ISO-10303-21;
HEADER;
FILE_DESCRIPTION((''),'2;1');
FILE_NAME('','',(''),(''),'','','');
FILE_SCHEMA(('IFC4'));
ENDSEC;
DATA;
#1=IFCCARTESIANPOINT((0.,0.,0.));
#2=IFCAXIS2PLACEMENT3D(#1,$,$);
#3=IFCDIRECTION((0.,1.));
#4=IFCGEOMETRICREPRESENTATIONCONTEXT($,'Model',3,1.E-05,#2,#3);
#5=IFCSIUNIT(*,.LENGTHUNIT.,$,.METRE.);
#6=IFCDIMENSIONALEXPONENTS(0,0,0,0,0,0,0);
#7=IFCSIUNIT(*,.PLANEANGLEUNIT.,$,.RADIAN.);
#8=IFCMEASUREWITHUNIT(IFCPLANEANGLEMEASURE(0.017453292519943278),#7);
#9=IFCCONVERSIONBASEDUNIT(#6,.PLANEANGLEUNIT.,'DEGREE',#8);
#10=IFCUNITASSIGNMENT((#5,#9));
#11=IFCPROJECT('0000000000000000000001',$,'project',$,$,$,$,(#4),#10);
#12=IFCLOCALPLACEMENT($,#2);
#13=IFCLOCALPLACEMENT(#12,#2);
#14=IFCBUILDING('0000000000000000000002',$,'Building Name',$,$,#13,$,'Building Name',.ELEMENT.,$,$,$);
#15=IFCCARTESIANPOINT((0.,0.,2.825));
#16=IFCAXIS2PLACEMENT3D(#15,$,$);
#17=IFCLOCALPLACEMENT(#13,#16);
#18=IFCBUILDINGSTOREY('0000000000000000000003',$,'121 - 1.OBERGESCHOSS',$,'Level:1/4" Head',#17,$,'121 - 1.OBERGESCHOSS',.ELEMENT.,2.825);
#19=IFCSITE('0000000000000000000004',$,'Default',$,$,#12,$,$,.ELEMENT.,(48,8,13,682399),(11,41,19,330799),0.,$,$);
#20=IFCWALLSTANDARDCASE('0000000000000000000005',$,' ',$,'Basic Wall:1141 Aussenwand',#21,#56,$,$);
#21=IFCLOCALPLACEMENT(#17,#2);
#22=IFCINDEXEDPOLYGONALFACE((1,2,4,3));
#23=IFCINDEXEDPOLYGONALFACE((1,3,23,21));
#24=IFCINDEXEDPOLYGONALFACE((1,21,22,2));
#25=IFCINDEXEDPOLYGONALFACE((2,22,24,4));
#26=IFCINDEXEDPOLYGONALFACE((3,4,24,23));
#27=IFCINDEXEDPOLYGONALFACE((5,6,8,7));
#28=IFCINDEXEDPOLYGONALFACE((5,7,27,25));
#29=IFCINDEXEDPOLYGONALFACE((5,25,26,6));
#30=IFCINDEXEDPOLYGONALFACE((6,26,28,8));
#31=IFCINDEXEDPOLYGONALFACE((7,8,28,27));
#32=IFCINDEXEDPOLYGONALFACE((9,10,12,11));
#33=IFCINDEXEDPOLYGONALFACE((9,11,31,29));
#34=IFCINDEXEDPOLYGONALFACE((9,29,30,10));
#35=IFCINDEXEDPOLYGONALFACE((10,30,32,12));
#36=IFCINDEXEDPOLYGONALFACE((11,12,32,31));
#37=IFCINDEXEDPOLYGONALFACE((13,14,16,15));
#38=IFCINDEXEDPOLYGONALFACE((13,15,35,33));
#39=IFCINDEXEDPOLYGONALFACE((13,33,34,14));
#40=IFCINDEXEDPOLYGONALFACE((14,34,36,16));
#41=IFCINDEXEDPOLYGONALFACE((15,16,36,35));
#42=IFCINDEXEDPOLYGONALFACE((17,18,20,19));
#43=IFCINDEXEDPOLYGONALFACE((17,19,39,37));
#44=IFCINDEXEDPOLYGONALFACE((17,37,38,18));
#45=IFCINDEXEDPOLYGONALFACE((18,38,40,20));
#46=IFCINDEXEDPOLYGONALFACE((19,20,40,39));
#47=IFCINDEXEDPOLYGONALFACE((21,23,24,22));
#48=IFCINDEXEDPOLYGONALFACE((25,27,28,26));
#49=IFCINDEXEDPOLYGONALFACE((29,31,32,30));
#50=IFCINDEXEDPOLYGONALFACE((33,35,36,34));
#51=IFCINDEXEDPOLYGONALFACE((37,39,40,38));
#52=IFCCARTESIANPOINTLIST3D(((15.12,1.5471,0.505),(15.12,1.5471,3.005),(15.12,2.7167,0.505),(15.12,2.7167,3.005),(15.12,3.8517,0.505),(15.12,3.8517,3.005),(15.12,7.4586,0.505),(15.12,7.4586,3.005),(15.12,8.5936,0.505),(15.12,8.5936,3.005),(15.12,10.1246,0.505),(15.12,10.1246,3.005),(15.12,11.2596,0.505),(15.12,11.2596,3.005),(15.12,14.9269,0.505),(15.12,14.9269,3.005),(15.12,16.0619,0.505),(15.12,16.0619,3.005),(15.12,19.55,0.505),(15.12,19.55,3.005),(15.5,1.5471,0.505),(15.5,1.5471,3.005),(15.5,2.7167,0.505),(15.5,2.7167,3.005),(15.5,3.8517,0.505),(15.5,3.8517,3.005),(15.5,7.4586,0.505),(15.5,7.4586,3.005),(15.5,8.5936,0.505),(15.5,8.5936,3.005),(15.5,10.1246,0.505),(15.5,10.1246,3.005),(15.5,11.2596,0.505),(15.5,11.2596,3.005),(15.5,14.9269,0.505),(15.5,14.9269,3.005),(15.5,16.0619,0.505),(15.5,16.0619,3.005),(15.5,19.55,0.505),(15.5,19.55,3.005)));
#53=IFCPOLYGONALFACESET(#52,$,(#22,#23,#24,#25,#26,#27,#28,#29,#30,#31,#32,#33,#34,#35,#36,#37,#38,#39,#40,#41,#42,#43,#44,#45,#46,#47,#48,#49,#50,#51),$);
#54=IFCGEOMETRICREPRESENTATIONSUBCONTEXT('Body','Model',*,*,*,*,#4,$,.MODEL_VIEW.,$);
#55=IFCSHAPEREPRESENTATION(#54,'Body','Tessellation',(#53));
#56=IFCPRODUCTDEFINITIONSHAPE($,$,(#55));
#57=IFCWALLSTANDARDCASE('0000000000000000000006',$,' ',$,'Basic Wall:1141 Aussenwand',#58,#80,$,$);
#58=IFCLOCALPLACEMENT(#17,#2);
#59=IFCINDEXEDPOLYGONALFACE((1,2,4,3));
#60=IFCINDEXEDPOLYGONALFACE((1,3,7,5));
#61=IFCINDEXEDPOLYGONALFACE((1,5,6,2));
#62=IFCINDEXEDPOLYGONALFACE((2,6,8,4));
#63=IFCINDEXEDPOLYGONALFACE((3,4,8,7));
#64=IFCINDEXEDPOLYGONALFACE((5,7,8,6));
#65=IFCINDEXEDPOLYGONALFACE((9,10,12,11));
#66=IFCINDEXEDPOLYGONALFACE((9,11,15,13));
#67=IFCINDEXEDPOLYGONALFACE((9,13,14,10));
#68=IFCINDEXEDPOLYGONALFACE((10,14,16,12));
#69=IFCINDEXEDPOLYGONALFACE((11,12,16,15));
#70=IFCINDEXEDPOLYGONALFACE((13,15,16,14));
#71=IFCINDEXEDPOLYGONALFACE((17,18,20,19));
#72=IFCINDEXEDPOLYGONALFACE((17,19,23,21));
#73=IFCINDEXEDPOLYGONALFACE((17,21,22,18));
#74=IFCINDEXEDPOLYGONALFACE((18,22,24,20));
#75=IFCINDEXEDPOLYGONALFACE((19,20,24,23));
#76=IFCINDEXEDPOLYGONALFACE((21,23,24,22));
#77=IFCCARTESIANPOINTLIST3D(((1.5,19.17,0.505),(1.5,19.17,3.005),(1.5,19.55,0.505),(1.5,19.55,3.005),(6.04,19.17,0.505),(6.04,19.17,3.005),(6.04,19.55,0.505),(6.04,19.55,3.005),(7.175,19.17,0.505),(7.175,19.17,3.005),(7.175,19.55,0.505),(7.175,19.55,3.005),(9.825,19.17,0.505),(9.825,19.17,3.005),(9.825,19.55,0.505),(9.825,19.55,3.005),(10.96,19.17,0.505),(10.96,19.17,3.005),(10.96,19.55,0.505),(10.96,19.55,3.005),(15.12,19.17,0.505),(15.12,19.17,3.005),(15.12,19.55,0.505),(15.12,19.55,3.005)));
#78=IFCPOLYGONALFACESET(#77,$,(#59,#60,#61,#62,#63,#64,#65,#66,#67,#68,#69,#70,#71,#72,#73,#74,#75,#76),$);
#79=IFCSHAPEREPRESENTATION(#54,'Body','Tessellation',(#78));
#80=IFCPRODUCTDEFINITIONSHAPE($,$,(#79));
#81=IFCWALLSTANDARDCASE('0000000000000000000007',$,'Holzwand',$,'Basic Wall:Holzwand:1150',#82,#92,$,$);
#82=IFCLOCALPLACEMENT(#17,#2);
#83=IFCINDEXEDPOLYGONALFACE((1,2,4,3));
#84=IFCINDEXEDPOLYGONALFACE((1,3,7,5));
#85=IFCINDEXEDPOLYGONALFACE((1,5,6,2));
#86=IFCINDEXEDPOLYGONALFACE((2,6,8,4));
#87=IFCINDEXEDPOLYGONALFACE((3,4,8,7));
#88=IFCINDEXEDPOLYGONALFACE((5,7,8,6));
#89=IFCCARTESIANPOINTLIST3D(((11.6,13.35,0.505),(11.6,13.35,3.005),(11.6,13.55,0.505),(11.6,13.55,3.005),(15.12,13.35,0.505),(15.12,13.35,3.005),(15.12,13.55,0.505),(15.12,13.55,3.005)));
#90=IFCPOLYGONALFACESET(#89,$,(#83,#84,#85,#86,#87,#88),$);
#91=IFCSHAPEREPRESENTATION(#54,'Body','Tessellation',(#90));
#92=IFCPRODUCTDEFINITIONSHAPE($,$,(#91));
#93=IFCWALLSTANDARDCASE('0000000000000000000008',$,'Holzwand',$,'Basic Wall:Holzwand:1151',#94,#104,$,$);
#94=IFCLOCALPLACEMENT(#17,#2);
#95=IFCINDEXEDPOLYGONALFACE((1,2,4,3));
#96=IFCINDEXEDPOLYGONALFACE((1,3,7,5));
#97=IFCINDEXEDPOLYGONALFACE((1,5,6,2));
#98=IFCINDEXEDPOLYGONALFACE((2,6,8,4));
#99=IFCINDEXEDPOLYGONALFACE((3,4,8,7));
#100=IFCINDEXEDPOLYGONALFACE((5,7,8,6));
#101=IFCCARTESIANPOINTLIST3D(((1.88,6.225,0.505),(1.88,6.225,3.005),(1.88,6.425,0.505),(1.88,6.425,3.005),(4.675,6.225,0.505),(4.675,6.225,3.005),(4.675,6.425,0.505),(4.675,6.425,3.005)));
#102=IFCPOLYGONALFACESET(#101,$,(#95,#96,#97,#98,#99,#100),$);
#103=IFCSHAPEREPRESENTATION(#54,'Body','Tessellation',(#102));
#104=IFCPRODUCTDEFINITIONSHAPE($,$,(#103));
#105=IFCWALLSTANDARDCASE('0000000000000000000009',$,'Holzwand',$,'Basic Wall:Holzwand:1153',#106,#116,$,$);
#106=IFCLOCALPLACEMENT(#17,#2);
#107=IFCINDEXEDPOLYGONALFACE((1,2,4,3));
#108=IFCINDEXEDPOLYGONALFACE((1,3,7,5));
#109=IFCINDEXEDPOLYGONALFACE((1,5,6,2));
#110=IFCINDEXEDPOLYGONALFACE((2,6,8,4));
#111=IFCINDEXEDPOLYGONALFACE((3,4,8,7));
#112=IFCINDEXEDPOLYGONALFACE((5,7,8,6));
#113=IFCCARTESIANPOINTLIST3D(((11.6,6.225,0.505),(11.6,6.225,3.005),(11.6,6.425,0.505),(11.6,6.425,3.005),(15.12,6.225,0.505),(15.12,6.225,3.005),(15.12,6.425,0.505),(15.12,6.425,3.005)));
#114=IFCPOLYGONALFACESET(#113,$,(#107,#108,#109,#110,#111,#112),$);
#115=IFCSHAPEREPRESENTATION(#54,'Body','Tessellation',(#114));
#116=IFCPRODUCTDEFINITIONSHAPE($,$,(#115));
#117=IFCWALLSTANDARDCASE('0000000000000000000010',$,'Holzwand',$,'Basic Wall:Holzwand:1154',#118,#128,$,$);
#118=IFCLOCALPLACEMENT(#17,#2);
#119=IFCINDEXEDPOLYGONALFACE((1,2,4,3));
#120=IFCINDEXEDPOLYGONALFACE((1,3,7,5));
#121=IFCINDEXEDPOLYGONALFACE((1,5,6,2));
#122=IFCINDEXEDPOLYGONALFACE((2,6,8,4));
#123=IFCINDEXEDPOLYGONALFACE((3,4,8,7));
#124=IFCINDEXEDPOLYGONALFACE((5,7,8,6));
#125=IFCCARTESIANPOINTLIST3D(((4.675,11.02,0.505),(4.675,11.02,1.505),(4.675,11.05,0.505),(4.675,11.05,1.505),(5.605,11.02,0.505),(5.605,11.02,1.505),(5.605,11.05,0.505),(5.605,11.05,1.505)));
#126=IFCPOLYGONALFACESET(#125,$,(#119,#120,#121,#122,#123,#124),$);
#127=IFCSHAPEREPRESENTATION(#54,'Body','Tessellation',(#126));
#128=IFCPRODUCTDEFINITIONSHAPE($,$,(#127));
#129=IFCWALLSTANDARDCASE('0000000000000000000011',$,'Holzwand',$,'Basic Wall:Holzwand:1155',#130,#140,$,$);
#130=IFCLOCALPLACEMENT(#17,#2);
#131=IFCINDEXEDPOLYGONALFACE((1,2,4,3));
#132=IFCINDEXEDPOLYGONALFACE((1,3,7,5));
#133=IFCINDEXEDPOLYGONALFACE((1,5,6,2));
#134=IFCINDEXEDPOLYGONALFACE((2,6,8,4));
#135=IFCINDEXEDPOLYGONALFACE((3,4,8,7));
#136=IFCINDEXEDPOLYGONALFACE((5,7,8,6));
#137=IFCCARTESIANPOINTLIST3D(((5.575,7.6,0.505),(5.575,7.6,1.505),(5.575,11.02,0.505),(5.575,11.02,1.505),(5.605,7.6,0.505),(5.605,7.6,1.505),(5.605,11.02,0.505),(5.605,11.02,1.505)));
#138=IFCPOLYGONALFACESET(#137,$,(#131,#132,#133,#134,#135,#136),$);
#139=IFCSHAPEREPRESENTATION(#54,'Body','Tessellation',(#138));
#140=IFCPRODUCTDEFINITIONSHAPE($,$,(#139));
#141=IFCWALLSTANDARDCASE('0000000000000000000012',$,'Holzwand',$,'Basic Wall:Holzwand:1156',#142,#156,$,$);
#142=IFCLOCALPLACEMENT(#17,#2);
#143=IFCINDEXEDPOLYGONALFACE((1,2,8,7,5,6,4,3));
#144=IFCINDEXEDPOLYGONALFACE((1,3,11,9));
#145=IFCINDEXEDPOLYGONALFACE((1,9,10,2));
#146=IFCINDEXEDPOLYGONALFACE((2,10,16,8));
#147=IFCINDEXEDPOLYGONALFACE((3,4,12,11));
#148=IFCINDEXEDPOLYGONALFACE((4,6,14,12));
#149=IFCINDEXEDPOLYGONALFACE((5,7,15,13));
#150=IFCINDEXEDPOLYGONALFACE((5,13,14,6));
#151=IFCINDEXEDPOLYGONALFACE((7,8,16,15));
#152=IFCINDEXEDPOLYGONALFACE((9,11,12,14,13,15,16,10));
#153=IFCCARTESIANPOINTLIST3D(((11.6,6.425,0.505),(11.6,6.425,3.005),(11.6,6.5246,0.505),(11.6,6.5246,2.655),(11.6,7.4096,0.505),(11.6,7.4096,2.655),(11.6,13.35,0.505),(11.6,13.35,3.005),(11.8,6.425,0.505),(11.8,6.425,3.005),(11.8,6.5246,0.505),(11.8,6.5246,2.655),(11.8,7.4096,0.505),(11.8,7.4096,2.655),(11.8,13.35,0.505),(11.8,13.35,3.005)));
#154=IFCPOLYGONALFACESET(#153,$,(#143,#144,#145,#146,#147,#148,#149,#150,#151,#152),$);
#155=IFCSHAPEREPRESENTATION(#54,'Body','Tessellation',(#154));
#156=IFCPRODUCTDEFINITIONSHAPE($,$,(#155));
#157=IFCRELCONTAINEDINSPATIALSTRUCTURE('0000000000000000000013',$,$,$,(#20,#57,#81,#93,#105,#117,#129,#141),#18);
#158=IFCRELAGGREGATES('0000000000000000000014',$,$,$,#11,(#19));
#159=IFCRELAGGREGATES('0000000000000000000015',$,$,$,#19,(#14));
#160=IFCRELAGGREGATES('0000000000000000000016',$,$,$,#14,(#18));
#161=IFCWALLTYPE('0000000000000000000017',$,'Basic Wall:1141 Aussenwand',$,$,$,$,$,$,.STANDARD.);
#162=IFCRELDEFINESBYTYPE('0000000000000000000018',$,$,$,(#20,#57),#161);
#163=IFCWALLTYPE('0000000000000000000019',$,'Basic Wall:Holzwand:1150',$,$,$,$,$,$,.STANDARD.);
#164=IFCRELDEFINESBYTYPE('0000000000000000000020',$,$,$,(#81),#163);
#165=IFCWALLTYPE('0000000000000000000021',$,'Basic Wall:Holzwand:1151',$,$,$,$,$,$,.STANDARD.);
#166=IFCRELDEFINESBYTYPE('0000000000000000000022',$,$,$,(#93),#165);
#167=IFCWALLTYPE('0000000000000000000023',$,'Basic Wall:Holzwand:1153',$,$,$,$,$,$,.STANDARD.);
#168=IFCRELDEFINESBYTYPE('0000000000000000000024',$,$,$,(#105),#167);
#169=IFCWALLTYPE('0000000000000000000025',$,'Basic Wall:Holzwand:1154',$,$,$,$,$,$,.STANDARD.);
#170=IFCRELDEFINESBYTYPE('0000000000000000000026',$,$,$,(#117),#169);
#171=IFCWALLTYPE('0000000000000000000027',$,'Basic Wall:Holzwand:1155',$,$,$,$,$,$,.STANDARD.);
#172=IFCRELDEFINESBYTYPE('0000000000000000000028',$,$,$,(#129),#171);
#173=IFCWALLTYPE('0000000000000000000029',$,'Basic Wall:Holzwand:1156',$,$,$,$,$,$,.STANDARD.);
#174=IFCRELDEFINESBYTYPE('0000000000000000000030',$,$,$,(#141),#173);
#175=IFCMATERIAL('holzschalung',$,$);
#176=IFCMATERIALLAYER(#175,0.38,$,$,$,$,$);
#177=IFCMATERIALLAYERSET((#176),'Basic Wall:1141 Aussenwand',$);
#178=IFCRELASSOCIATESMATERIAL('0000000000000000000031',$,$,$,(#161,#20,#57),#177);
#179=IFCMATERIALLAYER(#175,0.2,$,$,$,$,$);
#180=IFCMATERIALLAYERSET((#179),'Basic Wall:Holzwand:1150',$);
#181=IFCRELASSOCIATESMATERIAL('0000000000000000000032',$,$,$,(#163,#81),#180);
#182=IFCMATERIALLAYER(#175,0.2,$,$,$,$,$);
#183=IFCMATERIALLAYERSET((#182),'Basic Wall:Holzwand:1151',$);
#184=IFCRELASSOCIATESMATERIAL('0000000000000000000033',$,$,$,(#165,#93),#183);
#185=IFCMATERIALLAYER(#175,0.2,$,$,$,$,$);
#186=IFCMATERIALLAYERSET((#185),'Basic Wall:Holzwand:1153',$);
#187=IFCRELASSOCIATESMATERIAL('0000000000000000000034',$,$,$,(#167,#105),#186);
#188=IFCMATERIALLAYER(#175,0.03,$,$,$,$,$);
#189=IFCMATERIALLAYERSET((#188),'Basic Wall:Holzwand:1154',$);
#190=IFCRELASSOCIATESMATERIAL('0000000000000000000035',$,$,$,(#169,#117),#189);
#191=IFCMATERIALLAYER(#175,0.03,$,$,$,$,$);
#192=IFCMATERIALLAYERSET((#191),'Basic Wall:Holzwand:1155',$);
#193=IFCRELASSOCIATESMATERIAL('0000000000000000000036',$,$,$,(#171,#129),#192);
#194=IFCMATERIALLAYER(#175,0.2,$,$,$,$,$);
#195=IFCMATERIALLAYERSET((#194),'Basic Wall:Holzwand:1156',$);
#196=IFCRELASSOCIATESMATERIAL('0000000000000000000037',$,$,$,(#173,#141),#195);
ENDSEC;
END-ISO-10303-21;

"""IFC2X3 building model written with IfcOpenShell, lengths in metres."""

from ifc_helpers import new_model, entity, si_unit, converted_unit, direction, frame, frame_2d, origin, place, context, subcontext, project, spatial, rectangle, extrude, material, layer, layer_set, layer_usage, type_object, element, save


model = new_model("IFC2X3")

# Units and contexts
model_context = context("Model", 3, precision=1e-05, world=origin(), true_north=direction((0.0, 1.0)))
body_context = subcontext(model_context, "Body", "Model", "MODEL_VIEW")
ifc_project = project(units=[si_unit("LENGTHUNIT", "METRE"), converted_unit("PLANEANGLEUNIT", "DEGREE", entity("IfcPlaneAngleMeasure", 0.017453292519943278), si_unit("PLANEANGLEUNIT", "RADIAN"), dimensions=[0, 0, 0, 0, 0, 0, 0])], contexts=[model_context])

# Site, building, storey
site_placement = place(None, origin())
site = spatial("IfcSite", under=ifc_project, at=site_placement, Name="Default", CompositionType="ELEMENT", RefLatitude=(48, 8, 13, 682399), RefLongitude=(11, 41, 19, 330799), RefElevation=0.0)
building_placement = place(site_placement, origin())
building = spatial("IfcBuilding", under=site, at=building_placement, Name="Building Name", LongName="Building Name", CompositionType="ELEMENT")
storey_placement = place(building_placement, frame((0.0, 0.0, 2.825)))
storey = spatial("IfcBuildingStorey", under=building, at=storey_placement, Name="121 - 1.OBERGESCHOSS", ObjectType="Level:1/4\" Head", LongName="121 - 1.OBERGESCHOSS", CompositionType="ELEMENT", Elevation=2.825)

# Walls, openings
ifc_material = material(Name="holzschalung")
ifc_layer_1 = layer(ifc_material, 0.38)
ifc_layer_set_1 = layer_set([ifc_layer_1], Name="Basic Wall:1141 Aussenwand")
ifc_layer_usage_1 = layer_usage(ifc_layer_set_1, "AXIS2", "NEGATIVE", 0.19)
wall_type_1 = type_object("IfcWallType", Name="Basic Wall:1141 Aussenwand", PredefinedType="STANDARD", material=ifc_layer_set_1)
wall_1_placement = place(storey_placement, frame((15.31, 19.55, 0.505), z_axis=(0.0, 0.0, 1.0), x_axis=(0.0, -1.0, 0.0)))
wall_1 = element("IfcWallStandardCase", 1, at=wall_1_placement, inside=storey, type_object=wall_type_1, material=ifc_layer_usage_1, Name=" ", ObjectType="Basic Wall:1141 Aussenwand", context=body_context, shape_type="SweptSolid", body=[
    extrude(rectangle(XDim=18.0029, YDim=0.38, at=frame_2d((9.0014, 0.0), x_axis=(-1.0, 0.0))), origin(), (0.0, 0.0, 1.0), 2.5),
])
opening_1_placement = place(wall_1_placement, origin())
element("IfcOpeningElement", 2, at=opening_1_placement, cuts=wall_1, ObjectType="Opening", context=body_context, shape_type="SweptSolid", body=[
    extrude(rectangle(XDim=2.5, YDim=1.135, at=frame_2d((0.0, 0.0), x_axis=(1.0, 0.0))), frame((4.0556, -0.19, 1.25), z_axis=(0.0, 1.0, 0.0), x_axis=(0.0, 0.0, 1.0)), (0.0, 0.0, 1.0), 0.38),
])
opening_2_placement = place(wall_1_placement, origin())
element("IfcOpeningElement", 3, at=opening_2_placement, cuts=wall_1, ObjectType="Opening", context=body_context, shape_type="SweptSolid", body=[
    extrude(rectangle(XDim=2.5, YDim=1.135, at=frame_2d((0.0, 0.0), x_axis=(1.0, 0.0))), frame((8.8579, -0.19, 1.25), z_axis=(0.0, 1.0, 0.0), x_axis=(0.0, 0.0, 1.0)), (0.0, 0.0, 1.0), 0.38),
])
opening_3_placement = place(wall_1_placement, origin())
element("IfcOpeningElement", 4, at=opening_3_placement, cuts=wall_1, ObjectType="Opening", context=body_context, shape_type="SweptSolid", body=[
    extrude(rectangle(XDim=2.5, YDim=1.135, at=frame_2d((0.0, 0.0), x_axis=(1.0, 0.0))), frame((11.5239, -0.19, 1.25), z_axis=(0.0, 1.0, 0.0), x_axis=(0.0, 0.0, 1.0)), (0.0, 0.0, 1.0), 0.38),
])
opening_4_placement = place(wall_1_placement, origin())
element("IfcOpeningElement", 5, at=opening_4_placement, cuts=wall_1, ObjectType="Opening", context=body_context, shape_type="SweptSolid", body=[
    extrude(rectangle(XDim=2.5, YDim=1.135, at=frame_2d((0.0, 0.0), x_axis=(1.0, 0.0))), frame((16.2658, -0.19, 1.25), z_axis=(0.0, 1.0, 0.0), x_axis=(0.0, 0.0, 1.0)), (0.0, 0.0, 1.0), 0.38),
])
ifc_layer_usage_2 = layer_usage(ifc_layer_set_1, "AXIS2", "NEGATIVE", 0.19)
wall_2_placement = place(storey_placement, frame((1.5, 19.36, 0.505)))
wall_2 = element("IfcWallStandardCase", 6, at=wall_2_placement, inside=storey, type_object=wall_type_1, material=ifc_layer_usage_2, Name=" ", ObjectType="Basic Wall:1141 Aussenwand", context=body_context, shape_type="SweptSolid", body=[
    extrude(rectangle(XDim=13.62, YDim=0.38, at=frame_2d((6.81, 0.0), x_axis=(-1.0, 0.0))), origin(), (0.0, 0.0, 1.0), 2.5),
])
opening_5_placement = place(wall_2_placement, origin())
element("IfcOpeningElement", 7, at=opening_5_placement, cuts=wall_2, ObjectType="Opening", context=body_context, shape_type="SweptSolid", body=[
    extrude(rectangle(XDim=2.5, YDim=1.135, at=frame_2d((0.0, 0.0), x_axis=(1.0, 0.0))), frame((8.8925, -0.19, 1.25), z_axis=(0.0, 1.0, 0.0), x_axis=(0.0, 0.0, 1.0)), (0.0, 0.0, 1.0), 0.38),
])
opening_6_placement = place(wall_2_placement, origin())
element("IfcOpeningElement", 8, at=opening_6_placement, cuts=wall_2, ObjectType="Opening", context=body_context, shape_type="SweptSolid", body=[
    extrude(rectangle(XDim=2.5, YDim=1.135, at=frame_2d((0.0, 0.0), x_axis=(1.0, 0.0))), frame((5.1075, -0.19, 1.25), z_axis=(0.0, 1.0, 0.0), x_axis=(0.0, 0.0, 1.0)), (0.0, 0.0, 1.0), 0.38),
])

# Walls
ifc_layer_2 = layer(ifc_material, 0.2)
ifc_layer_set_2 = layer_set([ifc_layer_2], Name="Basic Wall:Holzwand:1150")
ifc_layer_usage_3 = layer_usage(ifc_layer_set_2, "AXIS2", "NEGATIVE", 0.1)
wall_type_2 = type_object("IfcWallType", Name="Basic Wall:Holzwand:1150", PredefinedType="STANDARD", material=ifc_layer_set_2)
wall_3_placement = place(storey_placement, frame((11.6, 13.45, 0.505)))
element("IfcWallStandardCase", 9, at=wall_3_placement, inside=storey, type_object=wall_type_2, material=ifc_layer_usage_3, Name="Holzwand", ObjectType="Basic Wall:Holzwand:1150", context=body_context, shape_type="SweptSolid", body=[
    extrude(rectangle(XDim=3.52, YDim=0.2, at=frame_2d((1.76, 0.0), x_axis=(-1.0, 0.0))), origin(), (0.0, 0.0, 1.0), 2.5),
])
ifc_layer_3 = layer(ifc_material, 0.2)
ifc_layer_set_3 = layer_set([ifc_layer_3], Name="Basic Wall:Holzwand:1151")
ifc_layer_usage_4 = layer_usage(ifc_layer_set_3, "AXIS2", "NEGATIVE", 0.1)
wall_type_3 = type_object("IfcWallType", Name="Basic Wall:Holzwand:1151", PredefinedType="STANDARD", material=ifc_layer_set_3)
wall_4_placement = place(storey_placement, frame((4.675, 6.325, 0.505), z_axis=(0.0, 0.0, 1.0), x_axis=(-1.0, 0.0, 0.0)))
element("IfcWallStandardCase", 10, at=wall_4_placement, inside=storey, type_object=wall_type_3, material=ifc_layer_usage_4, Name="Holzwand", ObjectType="Basic Wall:Holzwand:1151", context=body_context, shape_type="SweptSolid", body=[
    extrude(rectangle(XDim=2.795, YDim=0.2, at=frame_2d((1.3975, 0.0), x_axis=(-1.0, 0.0))), origin(), (0.0, 0.0, 1.0), 2.5),
])
ifc_layer_4 = layer(ifc_material, 0.2)
ifc_layer_set_4 = layer_set([ifc_layer_4], Name="Basic Wall:Holzwand:1153")
ifc_layer_usage_5 = layer_usage(ifc_layer_set_4, "AXIS2", "NEGATIVE", 0.1)
wall_type_4 = type_object("IfcWallType", Name="Basic Wall:Holzwand:1153", PredefinedType="STANDARD", material=ifc_layer_set_4)
wall_5_placement = place(storey_placement, frame((15.12, 6.325, 0.505), z_axis=(0.0, 0.0, 1.0), x_axis=(-1.0, 0.0, 0.0)))
element("IfcWallStandardCase", 11, at=wall_5_placement, inside=storey, type_object=wall_type_4, material=ifc_layer_usage_5, Name="Holzwand", ObjectType="Basic Wall:Holzwand:1153", context=body_context, shape_type="SweptSolid", body=[
    extrude(rectangle(XDim=3.52, YDim=0.2, at=frame_2d((1.76, 0.0), x_axis=(-1.0, 0.0))), origin(), (0.0, 0.0, 1.0), 2.5),
])
ifc_layer_5 = layer(ifc_material, 0.03)
ifc_layer_set_5 = layer_set([ifc_layer_5], Name="Basic Wall:Holzwand:1154")
ifc_layer_usage_6 = layer_usage(ifc_layer_set_5, "AXIS2", "NEGATIVE", 0.015)
wall_type_5 = type_object("IfcWallType", Name="Basic Wall:Holzwand:1154", PredefinedType="STANDARD", material=ifc_layer_set_5)
wall_6_placement = place(storey_placement, frame((5.605, 11.035, 0.505), z_axis=(0.0, 0.0, 1.0), x_axis=(-1.0, 0.0, 0.0)))
element("IfcWallStandardCase", 12, at=wall_6_placement, inside=storey, type_object=wall_type_5, material=ifc_layer_usage_6, Name="Holzwand", ObjectType="Basic Wall:Holzwand:1154", context=body_context, shape_type="SweptSolid", body=[
    extrude(rectangle(XDim=0.93, YDim=0.03, at=frame_2d((0.465, 0.0), x_axis=(-1.0, 0.0))), origin(), (0.0, 0.0, 1.0), 1.0),
])
ifc_layer_6 = layer(ifc_material, 0.03)
ifc_layer_set_6 = layer_set([ifc_layer_6], Name="Basic Wall:Holzwand:1155")
ifc_layer_usage_7 = layer_usage(ifc_layer_set_6, "AXIS2", "NEGATIVE", 0.015)
wall_type_6 = type_object("IfcWallType", Name="Basic Wall:Holzwand:1155", PredefinedType="STANDARD", material=ifc_layer_set_6)
wall_7_placement = place(storey_placement, frame((5.59, 7.6, 0.505), z_axis=(0.0, 0.0, 1.0), x_axis=(0.0, 1.0, 0.0)))
element("IfcWallStandardCase", 13, at=wall_7_placement, inside=storey, type_object=wall_type_6, material=ifc_layer_usage_7, Name="Holzwand", ObjectType="Basic Wall:Holzwand:1155", context=body_context, shape_type="SweptSolid", body=[
    extrude(rectangle(XDim=3.42, YDim=0.03, at=frame_2d((1.71, 0.0), x_axis=(-1.0, 0.0))), origin(), (0.0, 0.0, 1.0), 1.0),
])

# Wall, opening
ifc_layer_7 = layer(ifc_material, 0.2)
ifc_layer_set_7 = layer_set([ifc_layer_7], Name="Basic Wall:Holzwand:1156")
ifc_layer_usage_8 = layer_usage(ifc_layer_set_7, "AXIS2", "NEGATIVE", 0.1)
wall_type_7 = type_object("IfcWallType", Name="Basic Wall:Holzwand:1156", PredefinedType="STANDARD", material=ifc_layer_set_7)
wall_8_placement = place(storey_placement, frame((11.7, 6.425, 0.505), z_axis=(0.0, 0.0, 1.0), x_axis=(0.0, 1.0, 0.0)))
wall_8 = element("IfcWallStandardCase", 14, at=wall_8_placement, inside=storey, type_object=wall_type_7, material=ifc_layer_usage_8, Name="Holzwand", ObjectType="Basic Wall:Holzwand:1156", context=body_context, shape_type="SweptSolid", body=[
    extrude(rectangle(XDim=6.925, YDim=0.2, at=frame_2d((3.4625, 0.0), x_axis=(1.0, 0.0))), origin(), (0.0, 0.0, 1.0), 2.5),
])
opening_7_placement = place(wall_8_placement, frame((-6.425, 11.7, -0.505), z_axis=(0.0, 0.0, 1.0), x_axis=(0.0, -1.0, 0.0)))
element("IfcOpeningElement", 15, at=opening_7_placement, cuts=wall_8, ObjectType="Opening", context=body_context, shape_type="SweptSolid", body=[
    extrude(rectangle(XDim=2.3, YDim=0.885, at=frame_2d((0.0, 0.0), x_axis=(0.0, 1.0))), frame((11.802, 6.9671, 1.505), z_axis=(-1.0, 0.0, 0.0), x_axis=(0.0, -1.0, 0.0)), (0.0, 0.0, 1.0), 0.204),
])

save(model, "model.ifc")
